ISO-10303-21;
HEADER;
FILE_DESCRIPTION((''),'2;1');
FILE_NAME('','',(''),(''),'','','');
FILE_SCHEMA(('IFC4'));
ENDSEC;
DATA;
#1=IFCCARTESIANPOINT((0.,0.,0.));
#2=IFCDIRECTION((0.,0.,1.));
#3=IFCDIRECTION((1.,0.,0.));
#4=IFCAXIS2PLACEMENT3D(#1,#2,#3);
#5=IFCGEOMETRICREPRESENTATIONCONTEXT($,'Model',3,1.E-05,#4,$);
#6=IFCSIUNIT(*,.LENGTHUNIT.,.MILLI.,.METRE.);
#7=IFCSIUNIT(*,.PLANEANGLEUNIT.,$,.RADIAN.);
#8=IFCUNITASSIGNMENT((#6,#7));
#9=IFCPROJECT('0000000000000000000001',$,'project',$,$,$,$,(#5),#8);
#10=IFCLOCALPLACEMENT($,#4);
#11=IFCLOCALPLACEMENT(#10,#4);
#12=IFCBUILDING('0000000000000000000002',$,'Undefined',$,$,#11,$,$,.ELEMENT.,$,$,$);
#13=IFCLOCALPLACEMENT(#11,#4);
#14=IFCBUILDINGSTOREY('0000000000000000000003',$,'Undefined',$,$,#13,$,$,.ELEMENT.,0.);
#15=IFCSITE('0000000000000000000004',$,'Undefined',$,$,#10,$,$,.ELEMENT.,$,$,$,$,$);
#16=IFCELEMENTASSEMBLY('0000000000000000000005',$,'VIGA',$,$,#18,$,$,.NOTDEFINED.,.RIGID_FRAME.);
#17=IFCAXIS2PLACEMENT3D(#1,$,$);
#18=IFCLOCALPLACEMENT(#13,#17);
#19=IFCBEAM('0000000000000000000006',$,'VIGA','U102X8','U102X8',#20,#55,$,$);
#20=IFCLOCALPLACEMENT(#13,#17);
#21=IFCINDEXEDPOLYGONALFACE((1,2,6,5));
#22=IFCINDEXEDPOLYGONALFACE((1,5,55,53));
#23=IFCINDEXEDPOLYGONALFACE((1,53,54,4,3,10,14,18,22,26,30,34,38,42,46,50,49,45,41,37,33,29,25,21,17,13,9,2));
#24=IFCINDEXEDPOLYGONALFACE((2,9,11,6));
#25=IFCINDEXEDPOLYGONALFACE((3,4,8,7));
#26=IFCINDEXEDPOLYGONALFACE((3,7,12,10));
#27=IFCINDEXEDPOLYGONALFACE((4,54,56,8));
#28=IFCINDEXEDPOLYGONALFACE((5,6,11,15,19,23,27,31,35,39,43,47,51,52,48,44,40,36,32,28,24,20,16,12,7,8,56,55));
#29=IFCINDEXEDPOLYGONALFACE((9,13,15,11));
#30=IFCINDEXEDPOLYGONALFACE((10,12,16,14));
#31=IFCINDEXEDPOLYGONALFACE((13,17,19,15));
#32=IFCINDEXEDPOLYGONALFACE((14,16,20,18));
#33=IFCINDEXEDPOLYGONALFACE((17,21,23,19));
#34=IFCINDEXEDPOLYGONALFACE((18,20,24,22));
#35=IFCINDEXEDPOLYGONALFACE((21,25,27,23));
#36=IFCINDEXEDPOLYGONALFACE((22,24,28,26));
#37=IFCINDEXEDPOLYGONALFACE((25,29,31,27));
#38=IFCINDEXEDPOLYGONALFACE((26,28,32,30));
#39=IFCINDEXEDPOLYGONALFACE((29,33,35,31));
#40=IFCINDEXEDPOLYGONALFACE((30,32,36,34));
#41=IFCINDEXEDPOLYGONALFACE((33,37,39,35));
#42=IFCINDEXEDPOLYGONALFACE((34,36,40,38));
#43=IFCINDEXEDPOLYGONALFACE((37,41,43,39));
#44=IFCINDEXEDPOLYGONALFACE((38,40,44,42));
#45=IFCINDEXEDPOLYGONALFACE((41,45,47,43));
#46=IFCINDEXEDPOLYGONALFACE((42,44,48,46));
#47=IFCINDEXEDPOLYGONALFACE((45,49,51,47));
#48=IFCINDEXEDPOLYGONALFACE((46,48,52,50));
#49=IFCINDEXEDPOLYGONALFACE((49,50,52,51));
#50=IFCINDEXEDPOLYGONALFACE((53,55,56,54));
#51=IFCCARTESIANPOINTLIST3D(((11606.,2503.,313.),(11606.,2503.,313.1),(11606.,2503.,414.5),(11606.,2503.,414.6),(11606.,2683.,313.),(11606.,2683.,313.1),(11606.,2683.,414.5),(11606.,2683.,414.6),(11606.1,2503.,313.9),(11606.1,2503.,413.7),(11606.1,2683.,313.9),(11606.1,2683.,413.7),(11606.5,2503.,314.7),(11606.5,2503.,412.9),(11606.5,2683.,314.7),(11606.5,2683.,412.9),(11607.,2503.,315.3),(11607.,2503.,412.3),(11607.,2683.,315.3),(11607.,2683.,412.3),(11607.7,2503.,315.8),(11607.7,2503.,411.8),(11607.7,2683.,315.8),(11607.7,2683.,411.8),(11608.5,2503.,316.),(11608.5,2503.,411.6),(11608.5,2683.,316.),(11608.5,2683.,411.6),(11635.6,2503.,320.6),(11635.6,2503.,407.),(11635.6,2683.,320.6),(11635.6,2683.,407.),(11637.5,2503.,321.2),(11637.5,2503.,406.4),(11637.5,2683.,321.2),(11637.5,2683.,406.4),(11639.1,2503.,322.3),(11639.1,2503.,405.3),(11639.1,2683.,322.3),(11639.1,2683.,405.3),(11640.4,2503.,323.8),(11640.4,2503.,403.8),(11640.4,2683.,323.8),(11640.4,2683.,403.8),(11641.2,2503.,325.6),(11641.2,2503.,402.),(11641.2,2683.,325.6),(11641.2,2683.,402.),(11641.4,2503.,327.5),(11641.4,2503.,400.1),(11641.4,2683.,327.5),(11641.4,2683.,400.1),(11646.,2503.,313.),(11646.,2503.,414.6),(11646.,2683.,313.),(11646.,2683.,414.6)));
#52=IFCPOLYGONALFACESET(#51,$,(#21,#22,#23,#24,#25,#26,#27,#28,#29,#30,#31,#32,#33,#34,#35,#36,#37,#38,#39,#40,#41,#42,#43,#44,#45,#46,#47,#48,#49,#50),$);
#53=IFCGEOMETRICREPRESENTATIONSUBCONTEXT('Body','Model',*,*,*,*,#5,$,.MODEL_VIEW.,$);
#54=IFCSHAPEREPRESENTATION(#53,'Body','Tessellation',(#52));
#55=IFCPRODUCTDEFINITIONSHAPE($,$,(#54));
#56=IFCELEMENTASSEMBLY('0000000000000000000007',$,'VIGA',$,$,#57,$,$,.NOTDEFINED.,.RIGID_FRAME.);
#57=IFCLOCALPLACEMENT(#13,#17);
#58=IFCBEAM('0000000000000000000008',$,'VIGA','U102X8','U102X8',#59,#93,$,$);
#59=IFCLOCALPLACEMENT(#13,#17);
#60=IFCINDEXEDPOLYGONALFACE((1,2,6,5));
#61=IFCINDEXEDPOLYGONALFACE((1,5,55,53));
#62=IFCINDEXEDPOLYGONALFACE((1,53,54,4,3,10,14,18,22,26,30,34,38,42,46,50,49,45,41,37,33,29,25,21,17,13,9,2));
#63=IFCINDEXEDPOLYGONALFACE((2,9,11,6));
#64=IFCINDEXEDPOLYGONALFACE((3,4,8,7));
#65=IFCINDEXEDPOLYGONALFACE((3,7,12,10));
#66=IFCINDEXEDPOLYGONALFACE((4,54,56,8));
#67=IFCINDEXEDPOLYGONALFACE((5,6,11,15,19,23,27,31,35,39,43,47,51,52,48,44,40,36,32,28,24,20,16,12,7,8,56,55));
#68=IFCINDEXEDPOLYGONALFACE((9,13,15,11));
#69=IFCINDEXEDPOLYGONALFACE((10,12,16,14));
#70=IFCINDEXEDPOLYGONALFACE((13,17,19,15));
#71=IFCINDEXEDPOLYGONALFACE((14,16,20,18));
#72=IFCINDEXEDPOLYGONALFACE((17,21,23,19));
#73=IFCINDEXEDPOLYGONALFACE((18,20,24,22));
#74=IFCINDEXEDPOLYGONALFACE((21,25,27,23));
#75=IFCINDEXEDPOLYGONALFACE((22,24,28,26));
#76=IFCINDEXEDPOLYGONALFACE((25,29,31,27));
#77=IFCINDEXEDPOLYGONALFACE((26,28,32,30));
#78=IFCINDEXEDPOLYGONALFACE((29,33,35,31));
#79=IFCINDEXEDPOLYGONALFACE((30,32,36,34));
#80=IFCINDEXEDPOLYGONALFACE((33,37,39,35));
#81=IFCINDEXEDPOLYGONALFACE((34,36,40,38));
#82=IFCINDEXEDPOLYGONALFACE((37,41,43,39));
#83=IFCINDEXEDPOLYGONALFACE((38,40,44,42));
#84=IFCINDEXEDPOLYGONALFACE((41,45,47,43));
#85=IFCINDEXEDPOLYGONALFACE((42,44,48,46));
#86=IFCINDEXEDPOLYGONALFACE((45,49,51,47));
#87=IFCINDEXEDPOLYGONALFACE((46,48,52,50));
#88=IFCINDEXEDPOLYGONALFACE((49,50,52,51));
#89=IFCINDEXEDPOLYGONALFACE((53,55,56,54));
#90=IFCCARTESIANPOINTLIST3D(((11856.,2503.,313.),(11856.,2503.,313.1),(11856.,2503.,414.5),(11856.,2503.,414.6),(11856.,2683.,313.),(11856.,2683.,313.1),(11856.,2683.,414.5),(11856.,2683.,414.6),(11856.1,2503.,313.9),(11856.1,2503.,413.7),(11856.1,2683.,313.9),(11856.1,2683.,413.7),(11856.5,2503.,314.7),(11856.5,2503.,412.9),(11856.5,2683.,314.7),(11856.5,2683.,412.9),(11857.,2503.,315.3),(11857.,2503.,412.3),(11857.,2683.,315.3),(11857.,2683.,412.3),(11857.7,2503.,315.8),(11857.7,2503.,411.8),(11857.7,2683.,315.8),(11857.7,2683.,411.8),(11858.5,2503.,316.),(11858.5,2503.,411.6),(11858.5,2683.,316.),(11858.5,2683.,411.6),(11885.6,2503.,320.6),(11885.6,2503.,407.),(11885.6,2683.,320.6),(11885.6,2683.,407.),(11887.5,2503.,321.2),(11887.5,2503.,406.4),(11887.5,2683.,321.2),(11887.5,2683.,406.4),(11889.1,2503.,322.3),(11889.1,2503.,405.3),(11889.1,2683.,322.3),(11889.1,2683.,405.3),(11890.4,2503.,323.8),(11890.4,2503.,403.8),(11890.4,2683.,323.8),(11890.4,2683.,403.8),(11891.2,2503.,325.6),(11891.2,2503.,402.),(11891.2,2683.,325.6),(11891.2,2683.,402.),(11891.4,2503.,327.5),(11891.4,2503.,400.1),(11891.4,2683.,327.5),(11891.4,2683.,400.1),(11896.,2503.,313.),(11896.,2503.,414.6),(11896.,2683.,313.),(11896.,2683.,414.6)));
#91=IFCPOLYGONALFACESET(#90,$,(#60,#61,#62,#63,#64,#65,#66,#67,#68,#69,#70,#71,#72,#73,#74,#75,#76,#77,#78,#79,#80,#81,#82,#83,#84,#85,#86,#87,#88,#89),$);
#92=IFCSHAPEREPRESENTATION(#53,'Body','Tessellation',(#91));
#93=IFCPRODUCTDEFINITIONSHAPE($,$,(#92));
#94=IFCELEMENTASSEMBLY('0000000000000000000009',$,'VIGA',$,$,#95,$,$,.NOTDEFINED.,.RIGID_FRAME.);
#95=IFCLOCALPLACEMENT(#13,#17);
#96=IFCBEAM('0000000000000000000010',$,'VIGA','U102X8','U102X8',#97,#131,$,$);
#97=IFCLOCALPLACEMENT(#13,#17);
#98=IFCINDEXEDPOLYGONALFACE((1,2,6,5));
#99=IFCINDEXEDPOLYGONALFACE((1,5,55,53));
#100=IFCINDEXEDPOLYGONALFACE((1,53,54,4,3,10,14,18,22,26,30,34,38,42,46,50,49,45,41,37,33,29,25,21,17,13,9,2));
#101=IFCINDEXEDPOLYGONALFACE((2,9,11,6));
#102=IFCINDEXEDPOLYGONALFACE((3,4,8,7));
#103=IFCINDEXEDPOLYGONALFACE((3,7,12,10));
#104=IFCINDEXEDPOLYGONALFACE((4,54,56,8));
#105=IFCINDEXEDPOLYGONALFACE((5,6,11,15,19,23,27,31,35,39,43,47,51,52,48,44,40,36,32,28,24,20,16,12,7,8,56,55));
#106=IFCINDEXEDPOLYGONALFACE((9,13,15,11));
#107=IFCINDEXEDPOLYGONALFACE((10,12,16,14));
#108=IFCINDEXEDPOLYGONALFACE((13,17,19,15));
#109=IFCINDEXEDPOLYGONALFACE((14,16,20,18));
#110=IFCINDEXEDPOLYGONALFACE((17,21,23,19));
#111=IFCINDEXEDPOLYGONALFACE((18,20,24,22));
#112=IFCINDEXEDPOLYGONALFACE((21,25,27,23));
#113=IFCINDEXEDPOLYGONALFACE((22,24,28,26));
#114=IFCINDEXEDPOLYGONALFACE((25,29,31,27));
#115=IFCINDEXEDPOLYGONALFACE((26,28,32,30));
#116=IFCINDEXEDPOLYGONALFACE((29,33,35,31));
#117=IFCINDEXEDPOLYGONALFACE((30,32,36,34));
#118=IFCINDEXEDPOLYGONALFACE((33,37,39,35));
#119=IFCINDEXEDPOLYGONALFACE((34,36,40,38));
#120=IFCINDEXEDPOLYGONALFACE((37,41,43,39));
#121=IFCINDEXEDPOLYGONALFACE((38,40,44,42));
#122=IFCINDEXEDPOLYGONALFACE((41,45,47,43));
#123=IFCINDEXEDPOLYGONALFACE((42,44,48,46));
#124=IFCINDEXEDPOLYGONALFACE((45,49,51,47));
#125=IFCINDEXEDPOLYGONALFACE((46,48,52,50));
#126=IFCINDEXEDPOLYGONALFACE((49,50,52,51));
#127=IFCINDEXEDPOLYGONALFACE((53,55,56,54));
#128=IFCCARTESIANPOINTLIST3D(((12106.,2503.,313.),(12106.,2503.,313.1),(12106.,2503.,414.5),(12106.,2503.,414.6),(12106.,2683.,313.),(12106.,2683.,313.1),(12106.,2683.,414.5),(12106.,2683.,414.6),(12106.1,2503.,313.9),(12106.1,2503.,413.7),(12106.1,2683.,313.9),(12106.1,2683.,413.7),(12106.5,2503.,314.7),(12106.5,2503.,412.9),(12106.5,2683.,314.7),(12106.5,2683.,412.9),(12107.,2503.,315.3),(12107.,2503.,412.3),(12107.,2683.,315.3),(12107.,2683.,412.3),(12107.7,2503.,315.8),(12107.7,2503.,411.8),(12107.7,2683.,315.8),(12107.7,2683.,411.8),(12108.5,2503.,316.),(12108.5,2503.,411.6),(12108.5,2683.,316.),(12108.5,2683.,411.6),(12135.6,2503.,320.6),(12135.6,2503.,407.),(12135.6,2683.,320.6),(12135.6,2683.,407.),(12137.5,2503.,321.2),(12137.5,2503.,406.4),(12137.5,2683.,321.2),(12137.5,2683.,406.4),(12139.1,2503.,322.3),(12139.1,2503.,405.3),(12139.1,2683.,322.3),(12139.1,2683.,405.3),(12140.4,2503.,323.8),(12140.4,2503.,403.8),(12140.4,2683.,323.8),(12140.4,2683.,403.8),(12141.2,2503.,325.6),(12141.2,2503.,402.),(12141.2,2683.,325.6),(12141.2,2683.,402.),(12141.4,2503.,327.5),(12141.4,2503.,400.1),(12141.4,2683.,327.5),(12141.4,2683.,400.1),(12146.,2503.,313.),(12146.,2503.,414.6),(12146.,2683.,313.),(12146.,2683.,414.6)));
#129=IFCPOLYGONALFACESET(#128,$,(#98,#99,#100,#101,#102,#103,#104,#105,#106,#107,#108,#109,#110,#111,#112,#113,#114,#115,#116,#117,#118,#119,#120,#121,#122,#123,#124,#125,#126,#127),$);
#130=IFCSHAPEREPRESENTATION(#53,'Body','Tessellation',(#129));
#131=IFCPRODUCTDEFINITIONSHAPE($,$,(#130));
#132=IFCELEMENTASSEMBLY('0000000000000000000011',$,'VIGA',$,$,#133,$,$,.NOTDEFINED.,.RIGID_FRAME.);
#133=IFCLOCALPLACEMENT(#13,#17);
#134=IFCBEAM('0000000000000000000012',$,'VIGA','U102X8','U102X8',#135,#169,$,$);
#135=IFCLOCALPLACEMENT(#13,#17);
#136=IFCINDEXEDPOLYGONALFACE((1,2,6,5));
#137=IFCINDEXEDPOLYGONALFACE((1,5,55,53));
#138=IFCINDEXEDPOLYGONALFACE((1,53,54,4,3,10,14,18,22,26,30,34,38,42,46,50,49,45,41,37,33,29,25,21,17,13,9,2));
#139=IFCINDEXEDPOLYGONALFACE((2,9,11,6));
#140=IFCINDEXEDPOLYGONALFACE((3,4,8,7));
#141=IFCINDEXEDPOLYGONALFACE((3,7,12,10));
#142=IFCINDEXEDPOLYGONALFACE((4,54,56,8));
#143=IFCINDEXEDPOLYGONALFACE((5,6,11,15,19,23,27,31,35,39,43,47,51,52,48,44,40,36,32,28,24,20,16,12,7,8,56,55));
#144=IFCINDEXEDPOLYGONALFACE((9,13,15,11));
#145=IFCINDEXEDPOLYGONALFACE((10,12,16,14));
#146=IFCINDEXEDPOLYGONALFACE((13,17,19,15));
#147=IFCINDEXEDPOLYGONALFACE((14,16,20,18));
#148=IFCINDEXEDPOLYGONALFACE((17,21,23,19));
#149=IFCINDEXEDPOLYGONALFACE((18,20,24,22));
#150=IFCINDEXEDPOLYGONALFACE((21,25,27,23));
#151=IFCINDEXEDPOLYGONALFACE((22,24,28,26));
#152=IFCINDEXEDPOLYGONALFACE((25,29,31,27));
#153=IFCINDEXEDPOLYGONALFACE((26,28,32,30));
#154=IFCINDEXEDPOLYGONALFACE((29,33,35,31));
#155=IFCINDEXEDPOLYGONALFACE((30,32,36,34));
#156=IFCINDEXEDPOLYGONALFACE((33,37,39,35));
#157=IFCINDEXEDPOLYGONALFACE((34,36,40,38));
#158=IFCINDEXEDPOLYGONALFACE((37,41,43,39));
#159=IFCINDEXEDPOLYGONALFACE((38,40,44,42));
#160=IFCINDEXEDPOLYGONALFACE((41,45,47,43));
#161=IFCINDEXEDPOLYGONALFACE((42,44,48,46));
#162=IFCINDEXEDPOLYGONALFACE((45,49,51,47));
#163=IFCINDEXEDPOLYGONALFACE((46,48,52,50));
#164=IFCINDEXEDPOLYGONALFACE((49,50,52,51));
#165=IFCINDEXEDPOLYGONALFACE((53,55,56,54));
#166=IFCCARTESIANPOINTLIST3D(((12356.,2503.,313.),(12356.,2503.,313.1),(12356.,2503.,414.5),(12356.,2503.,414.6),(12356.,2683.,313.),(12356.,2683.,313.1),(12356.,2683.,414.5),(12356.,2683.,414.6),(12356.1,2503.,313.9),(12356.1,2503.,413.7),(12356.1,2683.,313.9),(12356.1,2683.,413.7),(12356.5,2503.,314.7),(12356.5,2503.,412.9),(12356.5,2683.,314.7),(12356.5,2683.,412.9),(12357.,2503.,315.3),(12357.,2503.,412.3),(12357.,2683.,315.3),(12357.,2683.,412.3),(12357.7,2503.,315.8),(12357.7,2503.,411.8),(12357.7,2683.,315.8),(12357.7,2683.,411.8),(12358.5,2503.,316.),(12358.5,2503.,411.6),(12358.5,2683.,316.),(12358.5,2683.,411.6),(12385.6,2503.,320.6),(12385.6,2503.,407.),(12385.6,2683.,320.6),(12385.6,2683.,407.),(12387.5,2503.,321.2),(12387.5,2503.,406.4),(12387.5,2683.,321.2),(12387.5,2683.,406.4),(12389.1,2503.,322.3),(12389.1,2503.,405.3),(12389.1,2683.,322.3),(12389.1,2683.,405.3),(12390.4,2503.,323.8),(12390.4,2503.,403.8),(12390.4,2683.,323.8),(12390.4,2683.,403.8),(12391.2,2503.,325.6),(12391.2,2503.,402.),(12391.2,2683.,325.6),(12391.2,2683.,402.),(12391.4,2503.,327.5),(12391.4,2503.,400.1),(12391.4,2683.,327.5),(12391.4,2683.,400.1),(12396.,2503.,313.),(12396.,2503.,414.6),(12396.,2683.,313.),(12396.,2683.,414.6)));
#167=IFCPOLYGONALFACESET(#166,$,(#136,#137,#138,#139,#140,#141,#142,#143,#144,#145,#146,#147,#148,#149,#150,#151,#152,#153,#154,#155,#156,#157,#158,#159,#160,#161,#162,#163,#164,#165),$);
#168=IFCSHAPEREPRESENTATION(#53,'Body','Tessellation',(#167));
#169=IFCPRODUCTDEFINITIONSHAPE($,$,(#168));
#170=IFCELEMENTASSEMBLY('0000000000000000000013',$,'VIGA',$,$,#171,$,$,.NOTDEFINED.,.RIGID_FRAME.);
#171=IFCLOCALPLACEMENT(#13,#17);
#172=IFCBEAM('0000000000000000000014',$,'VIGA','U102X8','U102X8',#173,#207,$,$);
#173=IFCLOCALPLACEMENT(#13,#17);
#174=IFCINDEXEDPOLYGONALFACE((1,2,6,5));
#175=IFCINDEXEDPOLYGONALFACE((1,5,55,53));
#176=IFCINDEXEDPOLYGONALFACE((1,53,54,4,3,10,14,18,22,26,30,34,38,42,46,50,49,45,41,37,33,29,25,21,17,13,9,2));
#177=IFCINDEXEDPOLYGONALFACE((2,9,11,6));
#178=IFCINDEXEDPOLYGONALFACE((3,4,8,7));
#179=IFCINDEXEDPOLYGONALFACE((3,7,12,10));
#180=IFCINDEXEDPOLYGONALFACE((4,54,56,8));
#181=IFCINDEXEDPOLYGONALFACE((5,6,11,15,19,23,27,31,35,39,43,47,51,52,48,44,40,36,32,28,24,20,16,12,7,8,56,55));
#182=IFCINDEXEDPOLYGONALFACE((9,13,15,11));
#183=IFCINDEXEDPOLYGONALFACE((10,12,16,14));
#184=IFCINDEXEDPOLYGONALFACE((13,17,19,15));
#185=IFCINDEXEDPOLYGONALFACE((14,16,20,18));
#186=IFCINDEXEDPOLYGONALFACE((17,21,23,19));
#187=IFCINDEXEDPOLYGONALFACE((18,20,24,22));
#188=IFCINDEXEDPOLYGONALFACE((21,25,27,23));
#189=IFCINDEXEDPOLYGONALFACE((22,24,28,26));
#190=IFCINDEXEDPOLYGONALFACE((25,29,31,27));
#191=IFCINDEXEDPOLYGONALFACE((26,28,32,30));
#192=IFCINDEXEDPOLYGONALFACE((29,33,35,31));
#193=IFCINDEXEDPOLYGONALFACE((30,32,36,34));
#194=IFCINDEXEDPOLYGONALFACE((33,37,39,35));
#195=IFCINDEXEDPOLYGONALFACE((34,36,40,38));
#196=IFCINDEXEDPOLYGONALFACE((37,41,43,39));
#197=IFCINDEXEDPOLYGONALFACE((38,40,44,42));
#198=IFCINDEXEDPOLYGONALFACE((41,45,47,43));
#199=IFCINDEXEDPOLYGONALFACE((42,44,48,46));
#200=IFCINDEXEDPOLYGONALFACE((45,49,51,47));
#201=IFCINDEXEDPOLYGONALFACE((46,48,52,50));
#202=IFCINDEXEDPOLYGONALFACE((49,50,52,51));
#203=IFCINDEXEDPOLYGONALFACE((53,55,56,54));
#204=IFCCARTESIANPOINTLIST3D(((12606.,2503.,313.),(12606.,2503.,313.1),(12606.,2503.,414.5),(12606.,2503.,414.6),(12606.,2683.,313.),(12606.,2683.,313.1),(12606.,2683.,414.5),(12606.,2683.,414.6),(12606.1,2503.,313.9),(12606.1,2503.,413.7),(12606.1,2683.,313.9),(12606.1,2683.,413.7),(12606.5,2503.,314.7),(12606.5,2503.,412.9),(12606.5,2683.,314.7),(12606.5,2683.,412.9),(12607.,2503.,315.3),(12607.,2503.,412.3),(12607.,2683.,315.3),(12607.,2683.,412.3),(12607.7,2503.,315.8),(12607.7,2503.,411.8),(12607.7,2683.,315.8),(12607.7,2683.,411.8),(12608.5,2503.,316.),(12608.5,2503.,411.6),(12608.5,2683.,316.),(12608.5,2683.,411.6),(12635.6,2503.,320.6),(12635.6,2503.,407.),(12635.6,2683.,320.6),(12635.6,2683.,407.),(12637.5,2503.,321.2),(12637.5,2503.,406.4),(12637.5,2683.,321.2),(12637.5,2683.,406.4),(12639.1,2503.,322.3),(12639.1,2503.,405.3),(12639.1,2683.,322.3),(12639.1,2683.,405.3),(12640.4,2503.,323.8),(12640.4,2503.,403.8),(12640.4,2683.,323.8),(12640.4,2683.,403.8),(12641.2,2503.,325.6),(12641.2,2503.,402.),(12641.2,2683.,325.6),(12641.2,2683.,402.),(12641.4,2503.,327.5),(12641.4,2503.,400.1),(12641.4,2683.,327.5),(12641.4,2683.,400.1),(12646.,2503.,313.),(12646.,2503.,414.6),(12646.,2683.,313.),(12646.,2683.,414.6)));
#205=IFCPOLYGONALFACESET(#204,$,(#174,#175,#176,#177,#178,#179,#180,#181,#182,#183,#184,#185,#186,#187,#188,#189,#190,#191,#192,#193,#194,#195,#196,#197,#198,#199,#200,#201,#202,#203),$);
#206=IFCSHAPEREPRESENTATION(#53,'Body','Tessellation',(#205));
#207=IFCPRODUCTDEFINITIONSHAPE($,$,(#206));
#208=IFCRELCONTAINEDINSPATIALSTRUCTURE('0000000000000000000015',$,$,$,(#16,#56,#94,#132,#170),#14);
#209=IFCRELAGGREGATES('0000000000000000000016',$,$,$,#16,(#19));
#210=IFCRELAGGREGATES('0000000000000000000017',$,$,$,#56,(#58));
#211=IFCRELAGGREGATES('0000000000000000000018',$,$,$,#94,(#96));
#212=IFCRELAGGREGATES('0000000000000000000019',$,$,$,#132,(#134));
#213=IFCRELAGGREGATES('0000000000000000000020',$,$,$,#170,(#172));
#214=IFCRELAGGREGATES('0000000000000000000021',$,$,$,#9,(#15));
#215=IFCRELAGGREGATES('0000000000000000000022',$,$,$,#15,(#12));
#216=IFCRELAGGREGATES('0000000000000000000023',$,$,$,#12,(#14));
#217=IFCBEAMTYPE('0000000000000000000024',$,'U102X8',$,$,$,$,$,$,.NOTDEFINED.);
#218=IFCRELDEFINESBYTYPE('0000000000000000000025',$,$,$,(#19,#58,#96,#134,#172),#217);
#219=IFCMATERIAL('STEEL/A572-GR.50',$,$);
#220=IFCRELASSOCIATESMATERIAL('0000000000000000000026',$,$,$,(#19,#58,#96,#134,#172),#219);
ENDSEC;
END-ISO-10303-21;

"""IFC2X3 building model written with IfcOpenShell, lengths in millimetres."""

from ifc_helpers import new_model, si_unit, frame, origin_with_axes, origin_2d_with_axis, place, context, subcontext, project, spatial, u_section, extrude, material, type_object, element, aggregate, save


model = new_model("IFC2X3")

# Units and contexts
model_context = context("Model", 3, precision=1e-05, world=origin_with_axes())
body_context = subcontext(model_context, "Body", "Model", "MODEL_VIEW")
ifc_project = project(units=[si_unit("LENGTHUNIT", "METRE", prefix="MILLI"), si_unit("PLANEANGLEUNIT", "RADIAN")], contexts=[model_context])

# Site, building, storey
site_placement = place(None, origin_with_axes())
site = spatial("IfcSite", under=ifc_project, at=site_placement, Name="Undefined", CompositionType="ELEMENT")
building_placement = place(site_placement, origin_with_axes())
building = spatial("IfcBuilding", under=site, at=building_placement, Name="Undefined", CompositionType="ELEMENT")
storey_placement = place(building_placement, origin_with_axes())
storey = spatial("IfcBuildingStorey", under=building, at=storey_placement, Name="Undefined", CompositionType="ELEMENT", Elevation=0.0)

# Element assemblies, beams
assembly_1_placement = place(storey_placement, origin_with_axes())
assembly_1 = element("IfcElementAssembly", 1, at=assembly_1_placement, inside=storey, Name="VIGA", AssemblyPlace="NOTDEFINED", PredefinedType="RIGID_FRAME")
ifc_material_1 = material(Name="STEEL/A572-GR.50")
beam_type_1 = type_object("IfcBeamType", Name="U102X8", PredefinedType="NOTDEFINED")
beam_1_placement = place(assembly_1_placement, frame((11626.0, 2683.0, 363.8), z_axis=(0.0, 0.0, 1.0), x_axis=(0.0, -1.0, 0.0)))
beam_1 = element("IfcBeam", 2, at=beam_1_placement, type_object=beam_type_1, material=ifc_material_1, Name="VIGA", Description="U102X8", ObjectType="U102X8", context=body_context, shape_type="SweptSolid", body=[
    extrude(u_section(Depth=101.6, FlangeWidth=40.0, WebThickness=4.6, FlangeThickness=6.0, FilletRadius=7.0, EdgeRadius=3.0, FlangeSlope=0.16839, at=origin_2d_with_axis()), frame((180.0, 0.0, 0.0), z_axis=(-1.0, 0.0, 0.0), x_axis=(0.0, -1.0, 0.0)), (0.0, 0.0, 1.0), 180.0),
])
aggregate(assembly_1, [beam_1])
assembly_2_placement = place(storey_placement, origin_with_axes())
assembly_2 = element("IfcElementAssembly", 3, at=assembly_2_placement, inside=storey, Name="VIGA", AssemblyPlace="NOTDEFINED", PredefinedType="RIGID_FRAME")
beam_2_placement = place(assembly_2_placement, frame((11876.0, 2683.0, 363.8), z_axis=(0.0, 0.0, 1.0), x_axis=(0.0, -1.0, 0.0)))
beam_2 = element("IfcBeam", 4, at=beam_2_placement, type_object=beam_type_1, material=ifc_material_1, Name="VIGA", Description="U102X8", ObjectType="U102X8", context=body_context, shape_type="SweptSolid", body=[
    extrude(u_section(Depth=101.6, FlangeWidth=40.0, WebThickness=4.6, FlangeThickness=6.0, FilletRadius=7.0, EdgeRadius=3.0, FlangeSlope=0.16839, at=origin_2d_with_axis()), frame((180.0, 0.0, 0.0), z_axis=(-1.0, 0.0, 0.0), x_axis=(0.0, -1.0, 0.0)), (0.0, 0.0, 1.0), 180.0),
])
aggregate(assembly_2, [beam_2])
assembly_3_placement = place(storey_placement, origin_with_axes())
assembly_3 = element("IfcElementAssembly", 5, at=assembly_3_placement, inside=storey, Name="VIGA", AssemblyPlace="NOTDEFINED", PredefinedType="RIGID_FRAME")
beam_3_placement = place(assembly_3_placement, frame((12126.0, 2683.0, 363.8), z_axis=(0.0, 0.0, 1.0), x_axis=(0.0, -1.0, 0.0)))
beam_3 = element("IfcBeam", 6, at=beam_3_placement, type_object=beam_type_1, material=ifc_material_1, Name="VIGA", Description="U102X8", ObjectType="U102X8", context=body_context, shape_type="SweptSolid", body=[
    extrude(u_section(Depth=101.6, FlangeWidth=40.0, WebThickness=4.6, FlangeThickness=6.0, FilletRadius=7.0, EdgeRadius=3.0, FlangeSlope=0.16839, at=origin_2d_with_axis()), frame((180.0, 0.0, 0.0), z_axis=(-1.0, 0.0, 0.0), x_axis=(0.0, -1.0, 0.0)), (0.0, 0.0, 1.0), 180.0),
])
aggregate(assembly_3, [beam_3])
assembly_4_placement = place(storey_placement, origin_with_axes())
assembly_4 = element("IfcElementAssembly", 7, at=assembly_4_placement, inside=storey, Name="VIGA", AssemblyPlace="NOTDEFINED", PredefinedType="RIGID_FRAME")
beam_4_placement = place(assembly_4_placement, frame((12376.0, 2683.0, 363.8), z_axis=(0.0, 0.0, 1.0), x_axis=(0.0, -1.0, 0.0)))
beam_4 = element("IfcBeam", 8, at=beam_4_placement, type_object=beam_type_1, material=ifc_material_1, Name="VIGA", Description="U102X8", ObjectType="U102X8", context=body_context, shape_type="SweptSolid", body=[
    extrude(u_section(Depth=101.6, FlangeWidth=40.0, WebThickness=4.6, FlangeThickness=6.0, FilletRadius=7.0, EdgeRadius=3.0, FlangeSlope=0.16839, at=origin_2d_with_axis()), frame((180.0, 0.0, 0.0), z_axis=(-1.0, 0.0, 0.0), x_axis=(0.0, -1.0, 0.0)), (0.0, 0.0, 1.0), 180.0),
])
aggregate(assembly_4, [beam_4])
assembly_5_placement = place(storey_placement, origin_with_axes())
assembly_5 = element("IfcElementAssembly", 9, at=assembly_5_placement, inside=storey, Name="VIGA", AssemblyPlace="NOTDEFINED", PredefinedType="RIGID_FRAME")
beam_5_placement = place(assembly_5_placement, frame((12626.0, 2683.0, 363.8), z_axis=(0.0, 0.0, 1.0), x_axis=(0.0, -1.0, 0.0)))
beam_5 = element("IfcBeam", 10, at=beam_5_placement, type_object=beam_type_1, material=ifc_material_1, Name="VIGA", Description="U102X8", ObjectType="U102X8", context=body_context, shape_type="SweptSolid", body=[
    extrude(u_section(Depth=101.6, FlangeWidth=40.0, WebThickness=4.6, FlangeThickness=6.0, FilletRadius=7.0, EdgeRadius=3.0, FlangeSlope=0.16839, at=origin_2d_with_axis()), frame((180.0, 0.0, 0.0), z_axis=(-1.0, 0.0, 0.0), x_axis=(0.0, -1.0, 0.0)), (0.0, 0.0, 1.0), 180.0),
])
aggregate(assembly_5, [beam_5])

save(model, "model.ifc")
